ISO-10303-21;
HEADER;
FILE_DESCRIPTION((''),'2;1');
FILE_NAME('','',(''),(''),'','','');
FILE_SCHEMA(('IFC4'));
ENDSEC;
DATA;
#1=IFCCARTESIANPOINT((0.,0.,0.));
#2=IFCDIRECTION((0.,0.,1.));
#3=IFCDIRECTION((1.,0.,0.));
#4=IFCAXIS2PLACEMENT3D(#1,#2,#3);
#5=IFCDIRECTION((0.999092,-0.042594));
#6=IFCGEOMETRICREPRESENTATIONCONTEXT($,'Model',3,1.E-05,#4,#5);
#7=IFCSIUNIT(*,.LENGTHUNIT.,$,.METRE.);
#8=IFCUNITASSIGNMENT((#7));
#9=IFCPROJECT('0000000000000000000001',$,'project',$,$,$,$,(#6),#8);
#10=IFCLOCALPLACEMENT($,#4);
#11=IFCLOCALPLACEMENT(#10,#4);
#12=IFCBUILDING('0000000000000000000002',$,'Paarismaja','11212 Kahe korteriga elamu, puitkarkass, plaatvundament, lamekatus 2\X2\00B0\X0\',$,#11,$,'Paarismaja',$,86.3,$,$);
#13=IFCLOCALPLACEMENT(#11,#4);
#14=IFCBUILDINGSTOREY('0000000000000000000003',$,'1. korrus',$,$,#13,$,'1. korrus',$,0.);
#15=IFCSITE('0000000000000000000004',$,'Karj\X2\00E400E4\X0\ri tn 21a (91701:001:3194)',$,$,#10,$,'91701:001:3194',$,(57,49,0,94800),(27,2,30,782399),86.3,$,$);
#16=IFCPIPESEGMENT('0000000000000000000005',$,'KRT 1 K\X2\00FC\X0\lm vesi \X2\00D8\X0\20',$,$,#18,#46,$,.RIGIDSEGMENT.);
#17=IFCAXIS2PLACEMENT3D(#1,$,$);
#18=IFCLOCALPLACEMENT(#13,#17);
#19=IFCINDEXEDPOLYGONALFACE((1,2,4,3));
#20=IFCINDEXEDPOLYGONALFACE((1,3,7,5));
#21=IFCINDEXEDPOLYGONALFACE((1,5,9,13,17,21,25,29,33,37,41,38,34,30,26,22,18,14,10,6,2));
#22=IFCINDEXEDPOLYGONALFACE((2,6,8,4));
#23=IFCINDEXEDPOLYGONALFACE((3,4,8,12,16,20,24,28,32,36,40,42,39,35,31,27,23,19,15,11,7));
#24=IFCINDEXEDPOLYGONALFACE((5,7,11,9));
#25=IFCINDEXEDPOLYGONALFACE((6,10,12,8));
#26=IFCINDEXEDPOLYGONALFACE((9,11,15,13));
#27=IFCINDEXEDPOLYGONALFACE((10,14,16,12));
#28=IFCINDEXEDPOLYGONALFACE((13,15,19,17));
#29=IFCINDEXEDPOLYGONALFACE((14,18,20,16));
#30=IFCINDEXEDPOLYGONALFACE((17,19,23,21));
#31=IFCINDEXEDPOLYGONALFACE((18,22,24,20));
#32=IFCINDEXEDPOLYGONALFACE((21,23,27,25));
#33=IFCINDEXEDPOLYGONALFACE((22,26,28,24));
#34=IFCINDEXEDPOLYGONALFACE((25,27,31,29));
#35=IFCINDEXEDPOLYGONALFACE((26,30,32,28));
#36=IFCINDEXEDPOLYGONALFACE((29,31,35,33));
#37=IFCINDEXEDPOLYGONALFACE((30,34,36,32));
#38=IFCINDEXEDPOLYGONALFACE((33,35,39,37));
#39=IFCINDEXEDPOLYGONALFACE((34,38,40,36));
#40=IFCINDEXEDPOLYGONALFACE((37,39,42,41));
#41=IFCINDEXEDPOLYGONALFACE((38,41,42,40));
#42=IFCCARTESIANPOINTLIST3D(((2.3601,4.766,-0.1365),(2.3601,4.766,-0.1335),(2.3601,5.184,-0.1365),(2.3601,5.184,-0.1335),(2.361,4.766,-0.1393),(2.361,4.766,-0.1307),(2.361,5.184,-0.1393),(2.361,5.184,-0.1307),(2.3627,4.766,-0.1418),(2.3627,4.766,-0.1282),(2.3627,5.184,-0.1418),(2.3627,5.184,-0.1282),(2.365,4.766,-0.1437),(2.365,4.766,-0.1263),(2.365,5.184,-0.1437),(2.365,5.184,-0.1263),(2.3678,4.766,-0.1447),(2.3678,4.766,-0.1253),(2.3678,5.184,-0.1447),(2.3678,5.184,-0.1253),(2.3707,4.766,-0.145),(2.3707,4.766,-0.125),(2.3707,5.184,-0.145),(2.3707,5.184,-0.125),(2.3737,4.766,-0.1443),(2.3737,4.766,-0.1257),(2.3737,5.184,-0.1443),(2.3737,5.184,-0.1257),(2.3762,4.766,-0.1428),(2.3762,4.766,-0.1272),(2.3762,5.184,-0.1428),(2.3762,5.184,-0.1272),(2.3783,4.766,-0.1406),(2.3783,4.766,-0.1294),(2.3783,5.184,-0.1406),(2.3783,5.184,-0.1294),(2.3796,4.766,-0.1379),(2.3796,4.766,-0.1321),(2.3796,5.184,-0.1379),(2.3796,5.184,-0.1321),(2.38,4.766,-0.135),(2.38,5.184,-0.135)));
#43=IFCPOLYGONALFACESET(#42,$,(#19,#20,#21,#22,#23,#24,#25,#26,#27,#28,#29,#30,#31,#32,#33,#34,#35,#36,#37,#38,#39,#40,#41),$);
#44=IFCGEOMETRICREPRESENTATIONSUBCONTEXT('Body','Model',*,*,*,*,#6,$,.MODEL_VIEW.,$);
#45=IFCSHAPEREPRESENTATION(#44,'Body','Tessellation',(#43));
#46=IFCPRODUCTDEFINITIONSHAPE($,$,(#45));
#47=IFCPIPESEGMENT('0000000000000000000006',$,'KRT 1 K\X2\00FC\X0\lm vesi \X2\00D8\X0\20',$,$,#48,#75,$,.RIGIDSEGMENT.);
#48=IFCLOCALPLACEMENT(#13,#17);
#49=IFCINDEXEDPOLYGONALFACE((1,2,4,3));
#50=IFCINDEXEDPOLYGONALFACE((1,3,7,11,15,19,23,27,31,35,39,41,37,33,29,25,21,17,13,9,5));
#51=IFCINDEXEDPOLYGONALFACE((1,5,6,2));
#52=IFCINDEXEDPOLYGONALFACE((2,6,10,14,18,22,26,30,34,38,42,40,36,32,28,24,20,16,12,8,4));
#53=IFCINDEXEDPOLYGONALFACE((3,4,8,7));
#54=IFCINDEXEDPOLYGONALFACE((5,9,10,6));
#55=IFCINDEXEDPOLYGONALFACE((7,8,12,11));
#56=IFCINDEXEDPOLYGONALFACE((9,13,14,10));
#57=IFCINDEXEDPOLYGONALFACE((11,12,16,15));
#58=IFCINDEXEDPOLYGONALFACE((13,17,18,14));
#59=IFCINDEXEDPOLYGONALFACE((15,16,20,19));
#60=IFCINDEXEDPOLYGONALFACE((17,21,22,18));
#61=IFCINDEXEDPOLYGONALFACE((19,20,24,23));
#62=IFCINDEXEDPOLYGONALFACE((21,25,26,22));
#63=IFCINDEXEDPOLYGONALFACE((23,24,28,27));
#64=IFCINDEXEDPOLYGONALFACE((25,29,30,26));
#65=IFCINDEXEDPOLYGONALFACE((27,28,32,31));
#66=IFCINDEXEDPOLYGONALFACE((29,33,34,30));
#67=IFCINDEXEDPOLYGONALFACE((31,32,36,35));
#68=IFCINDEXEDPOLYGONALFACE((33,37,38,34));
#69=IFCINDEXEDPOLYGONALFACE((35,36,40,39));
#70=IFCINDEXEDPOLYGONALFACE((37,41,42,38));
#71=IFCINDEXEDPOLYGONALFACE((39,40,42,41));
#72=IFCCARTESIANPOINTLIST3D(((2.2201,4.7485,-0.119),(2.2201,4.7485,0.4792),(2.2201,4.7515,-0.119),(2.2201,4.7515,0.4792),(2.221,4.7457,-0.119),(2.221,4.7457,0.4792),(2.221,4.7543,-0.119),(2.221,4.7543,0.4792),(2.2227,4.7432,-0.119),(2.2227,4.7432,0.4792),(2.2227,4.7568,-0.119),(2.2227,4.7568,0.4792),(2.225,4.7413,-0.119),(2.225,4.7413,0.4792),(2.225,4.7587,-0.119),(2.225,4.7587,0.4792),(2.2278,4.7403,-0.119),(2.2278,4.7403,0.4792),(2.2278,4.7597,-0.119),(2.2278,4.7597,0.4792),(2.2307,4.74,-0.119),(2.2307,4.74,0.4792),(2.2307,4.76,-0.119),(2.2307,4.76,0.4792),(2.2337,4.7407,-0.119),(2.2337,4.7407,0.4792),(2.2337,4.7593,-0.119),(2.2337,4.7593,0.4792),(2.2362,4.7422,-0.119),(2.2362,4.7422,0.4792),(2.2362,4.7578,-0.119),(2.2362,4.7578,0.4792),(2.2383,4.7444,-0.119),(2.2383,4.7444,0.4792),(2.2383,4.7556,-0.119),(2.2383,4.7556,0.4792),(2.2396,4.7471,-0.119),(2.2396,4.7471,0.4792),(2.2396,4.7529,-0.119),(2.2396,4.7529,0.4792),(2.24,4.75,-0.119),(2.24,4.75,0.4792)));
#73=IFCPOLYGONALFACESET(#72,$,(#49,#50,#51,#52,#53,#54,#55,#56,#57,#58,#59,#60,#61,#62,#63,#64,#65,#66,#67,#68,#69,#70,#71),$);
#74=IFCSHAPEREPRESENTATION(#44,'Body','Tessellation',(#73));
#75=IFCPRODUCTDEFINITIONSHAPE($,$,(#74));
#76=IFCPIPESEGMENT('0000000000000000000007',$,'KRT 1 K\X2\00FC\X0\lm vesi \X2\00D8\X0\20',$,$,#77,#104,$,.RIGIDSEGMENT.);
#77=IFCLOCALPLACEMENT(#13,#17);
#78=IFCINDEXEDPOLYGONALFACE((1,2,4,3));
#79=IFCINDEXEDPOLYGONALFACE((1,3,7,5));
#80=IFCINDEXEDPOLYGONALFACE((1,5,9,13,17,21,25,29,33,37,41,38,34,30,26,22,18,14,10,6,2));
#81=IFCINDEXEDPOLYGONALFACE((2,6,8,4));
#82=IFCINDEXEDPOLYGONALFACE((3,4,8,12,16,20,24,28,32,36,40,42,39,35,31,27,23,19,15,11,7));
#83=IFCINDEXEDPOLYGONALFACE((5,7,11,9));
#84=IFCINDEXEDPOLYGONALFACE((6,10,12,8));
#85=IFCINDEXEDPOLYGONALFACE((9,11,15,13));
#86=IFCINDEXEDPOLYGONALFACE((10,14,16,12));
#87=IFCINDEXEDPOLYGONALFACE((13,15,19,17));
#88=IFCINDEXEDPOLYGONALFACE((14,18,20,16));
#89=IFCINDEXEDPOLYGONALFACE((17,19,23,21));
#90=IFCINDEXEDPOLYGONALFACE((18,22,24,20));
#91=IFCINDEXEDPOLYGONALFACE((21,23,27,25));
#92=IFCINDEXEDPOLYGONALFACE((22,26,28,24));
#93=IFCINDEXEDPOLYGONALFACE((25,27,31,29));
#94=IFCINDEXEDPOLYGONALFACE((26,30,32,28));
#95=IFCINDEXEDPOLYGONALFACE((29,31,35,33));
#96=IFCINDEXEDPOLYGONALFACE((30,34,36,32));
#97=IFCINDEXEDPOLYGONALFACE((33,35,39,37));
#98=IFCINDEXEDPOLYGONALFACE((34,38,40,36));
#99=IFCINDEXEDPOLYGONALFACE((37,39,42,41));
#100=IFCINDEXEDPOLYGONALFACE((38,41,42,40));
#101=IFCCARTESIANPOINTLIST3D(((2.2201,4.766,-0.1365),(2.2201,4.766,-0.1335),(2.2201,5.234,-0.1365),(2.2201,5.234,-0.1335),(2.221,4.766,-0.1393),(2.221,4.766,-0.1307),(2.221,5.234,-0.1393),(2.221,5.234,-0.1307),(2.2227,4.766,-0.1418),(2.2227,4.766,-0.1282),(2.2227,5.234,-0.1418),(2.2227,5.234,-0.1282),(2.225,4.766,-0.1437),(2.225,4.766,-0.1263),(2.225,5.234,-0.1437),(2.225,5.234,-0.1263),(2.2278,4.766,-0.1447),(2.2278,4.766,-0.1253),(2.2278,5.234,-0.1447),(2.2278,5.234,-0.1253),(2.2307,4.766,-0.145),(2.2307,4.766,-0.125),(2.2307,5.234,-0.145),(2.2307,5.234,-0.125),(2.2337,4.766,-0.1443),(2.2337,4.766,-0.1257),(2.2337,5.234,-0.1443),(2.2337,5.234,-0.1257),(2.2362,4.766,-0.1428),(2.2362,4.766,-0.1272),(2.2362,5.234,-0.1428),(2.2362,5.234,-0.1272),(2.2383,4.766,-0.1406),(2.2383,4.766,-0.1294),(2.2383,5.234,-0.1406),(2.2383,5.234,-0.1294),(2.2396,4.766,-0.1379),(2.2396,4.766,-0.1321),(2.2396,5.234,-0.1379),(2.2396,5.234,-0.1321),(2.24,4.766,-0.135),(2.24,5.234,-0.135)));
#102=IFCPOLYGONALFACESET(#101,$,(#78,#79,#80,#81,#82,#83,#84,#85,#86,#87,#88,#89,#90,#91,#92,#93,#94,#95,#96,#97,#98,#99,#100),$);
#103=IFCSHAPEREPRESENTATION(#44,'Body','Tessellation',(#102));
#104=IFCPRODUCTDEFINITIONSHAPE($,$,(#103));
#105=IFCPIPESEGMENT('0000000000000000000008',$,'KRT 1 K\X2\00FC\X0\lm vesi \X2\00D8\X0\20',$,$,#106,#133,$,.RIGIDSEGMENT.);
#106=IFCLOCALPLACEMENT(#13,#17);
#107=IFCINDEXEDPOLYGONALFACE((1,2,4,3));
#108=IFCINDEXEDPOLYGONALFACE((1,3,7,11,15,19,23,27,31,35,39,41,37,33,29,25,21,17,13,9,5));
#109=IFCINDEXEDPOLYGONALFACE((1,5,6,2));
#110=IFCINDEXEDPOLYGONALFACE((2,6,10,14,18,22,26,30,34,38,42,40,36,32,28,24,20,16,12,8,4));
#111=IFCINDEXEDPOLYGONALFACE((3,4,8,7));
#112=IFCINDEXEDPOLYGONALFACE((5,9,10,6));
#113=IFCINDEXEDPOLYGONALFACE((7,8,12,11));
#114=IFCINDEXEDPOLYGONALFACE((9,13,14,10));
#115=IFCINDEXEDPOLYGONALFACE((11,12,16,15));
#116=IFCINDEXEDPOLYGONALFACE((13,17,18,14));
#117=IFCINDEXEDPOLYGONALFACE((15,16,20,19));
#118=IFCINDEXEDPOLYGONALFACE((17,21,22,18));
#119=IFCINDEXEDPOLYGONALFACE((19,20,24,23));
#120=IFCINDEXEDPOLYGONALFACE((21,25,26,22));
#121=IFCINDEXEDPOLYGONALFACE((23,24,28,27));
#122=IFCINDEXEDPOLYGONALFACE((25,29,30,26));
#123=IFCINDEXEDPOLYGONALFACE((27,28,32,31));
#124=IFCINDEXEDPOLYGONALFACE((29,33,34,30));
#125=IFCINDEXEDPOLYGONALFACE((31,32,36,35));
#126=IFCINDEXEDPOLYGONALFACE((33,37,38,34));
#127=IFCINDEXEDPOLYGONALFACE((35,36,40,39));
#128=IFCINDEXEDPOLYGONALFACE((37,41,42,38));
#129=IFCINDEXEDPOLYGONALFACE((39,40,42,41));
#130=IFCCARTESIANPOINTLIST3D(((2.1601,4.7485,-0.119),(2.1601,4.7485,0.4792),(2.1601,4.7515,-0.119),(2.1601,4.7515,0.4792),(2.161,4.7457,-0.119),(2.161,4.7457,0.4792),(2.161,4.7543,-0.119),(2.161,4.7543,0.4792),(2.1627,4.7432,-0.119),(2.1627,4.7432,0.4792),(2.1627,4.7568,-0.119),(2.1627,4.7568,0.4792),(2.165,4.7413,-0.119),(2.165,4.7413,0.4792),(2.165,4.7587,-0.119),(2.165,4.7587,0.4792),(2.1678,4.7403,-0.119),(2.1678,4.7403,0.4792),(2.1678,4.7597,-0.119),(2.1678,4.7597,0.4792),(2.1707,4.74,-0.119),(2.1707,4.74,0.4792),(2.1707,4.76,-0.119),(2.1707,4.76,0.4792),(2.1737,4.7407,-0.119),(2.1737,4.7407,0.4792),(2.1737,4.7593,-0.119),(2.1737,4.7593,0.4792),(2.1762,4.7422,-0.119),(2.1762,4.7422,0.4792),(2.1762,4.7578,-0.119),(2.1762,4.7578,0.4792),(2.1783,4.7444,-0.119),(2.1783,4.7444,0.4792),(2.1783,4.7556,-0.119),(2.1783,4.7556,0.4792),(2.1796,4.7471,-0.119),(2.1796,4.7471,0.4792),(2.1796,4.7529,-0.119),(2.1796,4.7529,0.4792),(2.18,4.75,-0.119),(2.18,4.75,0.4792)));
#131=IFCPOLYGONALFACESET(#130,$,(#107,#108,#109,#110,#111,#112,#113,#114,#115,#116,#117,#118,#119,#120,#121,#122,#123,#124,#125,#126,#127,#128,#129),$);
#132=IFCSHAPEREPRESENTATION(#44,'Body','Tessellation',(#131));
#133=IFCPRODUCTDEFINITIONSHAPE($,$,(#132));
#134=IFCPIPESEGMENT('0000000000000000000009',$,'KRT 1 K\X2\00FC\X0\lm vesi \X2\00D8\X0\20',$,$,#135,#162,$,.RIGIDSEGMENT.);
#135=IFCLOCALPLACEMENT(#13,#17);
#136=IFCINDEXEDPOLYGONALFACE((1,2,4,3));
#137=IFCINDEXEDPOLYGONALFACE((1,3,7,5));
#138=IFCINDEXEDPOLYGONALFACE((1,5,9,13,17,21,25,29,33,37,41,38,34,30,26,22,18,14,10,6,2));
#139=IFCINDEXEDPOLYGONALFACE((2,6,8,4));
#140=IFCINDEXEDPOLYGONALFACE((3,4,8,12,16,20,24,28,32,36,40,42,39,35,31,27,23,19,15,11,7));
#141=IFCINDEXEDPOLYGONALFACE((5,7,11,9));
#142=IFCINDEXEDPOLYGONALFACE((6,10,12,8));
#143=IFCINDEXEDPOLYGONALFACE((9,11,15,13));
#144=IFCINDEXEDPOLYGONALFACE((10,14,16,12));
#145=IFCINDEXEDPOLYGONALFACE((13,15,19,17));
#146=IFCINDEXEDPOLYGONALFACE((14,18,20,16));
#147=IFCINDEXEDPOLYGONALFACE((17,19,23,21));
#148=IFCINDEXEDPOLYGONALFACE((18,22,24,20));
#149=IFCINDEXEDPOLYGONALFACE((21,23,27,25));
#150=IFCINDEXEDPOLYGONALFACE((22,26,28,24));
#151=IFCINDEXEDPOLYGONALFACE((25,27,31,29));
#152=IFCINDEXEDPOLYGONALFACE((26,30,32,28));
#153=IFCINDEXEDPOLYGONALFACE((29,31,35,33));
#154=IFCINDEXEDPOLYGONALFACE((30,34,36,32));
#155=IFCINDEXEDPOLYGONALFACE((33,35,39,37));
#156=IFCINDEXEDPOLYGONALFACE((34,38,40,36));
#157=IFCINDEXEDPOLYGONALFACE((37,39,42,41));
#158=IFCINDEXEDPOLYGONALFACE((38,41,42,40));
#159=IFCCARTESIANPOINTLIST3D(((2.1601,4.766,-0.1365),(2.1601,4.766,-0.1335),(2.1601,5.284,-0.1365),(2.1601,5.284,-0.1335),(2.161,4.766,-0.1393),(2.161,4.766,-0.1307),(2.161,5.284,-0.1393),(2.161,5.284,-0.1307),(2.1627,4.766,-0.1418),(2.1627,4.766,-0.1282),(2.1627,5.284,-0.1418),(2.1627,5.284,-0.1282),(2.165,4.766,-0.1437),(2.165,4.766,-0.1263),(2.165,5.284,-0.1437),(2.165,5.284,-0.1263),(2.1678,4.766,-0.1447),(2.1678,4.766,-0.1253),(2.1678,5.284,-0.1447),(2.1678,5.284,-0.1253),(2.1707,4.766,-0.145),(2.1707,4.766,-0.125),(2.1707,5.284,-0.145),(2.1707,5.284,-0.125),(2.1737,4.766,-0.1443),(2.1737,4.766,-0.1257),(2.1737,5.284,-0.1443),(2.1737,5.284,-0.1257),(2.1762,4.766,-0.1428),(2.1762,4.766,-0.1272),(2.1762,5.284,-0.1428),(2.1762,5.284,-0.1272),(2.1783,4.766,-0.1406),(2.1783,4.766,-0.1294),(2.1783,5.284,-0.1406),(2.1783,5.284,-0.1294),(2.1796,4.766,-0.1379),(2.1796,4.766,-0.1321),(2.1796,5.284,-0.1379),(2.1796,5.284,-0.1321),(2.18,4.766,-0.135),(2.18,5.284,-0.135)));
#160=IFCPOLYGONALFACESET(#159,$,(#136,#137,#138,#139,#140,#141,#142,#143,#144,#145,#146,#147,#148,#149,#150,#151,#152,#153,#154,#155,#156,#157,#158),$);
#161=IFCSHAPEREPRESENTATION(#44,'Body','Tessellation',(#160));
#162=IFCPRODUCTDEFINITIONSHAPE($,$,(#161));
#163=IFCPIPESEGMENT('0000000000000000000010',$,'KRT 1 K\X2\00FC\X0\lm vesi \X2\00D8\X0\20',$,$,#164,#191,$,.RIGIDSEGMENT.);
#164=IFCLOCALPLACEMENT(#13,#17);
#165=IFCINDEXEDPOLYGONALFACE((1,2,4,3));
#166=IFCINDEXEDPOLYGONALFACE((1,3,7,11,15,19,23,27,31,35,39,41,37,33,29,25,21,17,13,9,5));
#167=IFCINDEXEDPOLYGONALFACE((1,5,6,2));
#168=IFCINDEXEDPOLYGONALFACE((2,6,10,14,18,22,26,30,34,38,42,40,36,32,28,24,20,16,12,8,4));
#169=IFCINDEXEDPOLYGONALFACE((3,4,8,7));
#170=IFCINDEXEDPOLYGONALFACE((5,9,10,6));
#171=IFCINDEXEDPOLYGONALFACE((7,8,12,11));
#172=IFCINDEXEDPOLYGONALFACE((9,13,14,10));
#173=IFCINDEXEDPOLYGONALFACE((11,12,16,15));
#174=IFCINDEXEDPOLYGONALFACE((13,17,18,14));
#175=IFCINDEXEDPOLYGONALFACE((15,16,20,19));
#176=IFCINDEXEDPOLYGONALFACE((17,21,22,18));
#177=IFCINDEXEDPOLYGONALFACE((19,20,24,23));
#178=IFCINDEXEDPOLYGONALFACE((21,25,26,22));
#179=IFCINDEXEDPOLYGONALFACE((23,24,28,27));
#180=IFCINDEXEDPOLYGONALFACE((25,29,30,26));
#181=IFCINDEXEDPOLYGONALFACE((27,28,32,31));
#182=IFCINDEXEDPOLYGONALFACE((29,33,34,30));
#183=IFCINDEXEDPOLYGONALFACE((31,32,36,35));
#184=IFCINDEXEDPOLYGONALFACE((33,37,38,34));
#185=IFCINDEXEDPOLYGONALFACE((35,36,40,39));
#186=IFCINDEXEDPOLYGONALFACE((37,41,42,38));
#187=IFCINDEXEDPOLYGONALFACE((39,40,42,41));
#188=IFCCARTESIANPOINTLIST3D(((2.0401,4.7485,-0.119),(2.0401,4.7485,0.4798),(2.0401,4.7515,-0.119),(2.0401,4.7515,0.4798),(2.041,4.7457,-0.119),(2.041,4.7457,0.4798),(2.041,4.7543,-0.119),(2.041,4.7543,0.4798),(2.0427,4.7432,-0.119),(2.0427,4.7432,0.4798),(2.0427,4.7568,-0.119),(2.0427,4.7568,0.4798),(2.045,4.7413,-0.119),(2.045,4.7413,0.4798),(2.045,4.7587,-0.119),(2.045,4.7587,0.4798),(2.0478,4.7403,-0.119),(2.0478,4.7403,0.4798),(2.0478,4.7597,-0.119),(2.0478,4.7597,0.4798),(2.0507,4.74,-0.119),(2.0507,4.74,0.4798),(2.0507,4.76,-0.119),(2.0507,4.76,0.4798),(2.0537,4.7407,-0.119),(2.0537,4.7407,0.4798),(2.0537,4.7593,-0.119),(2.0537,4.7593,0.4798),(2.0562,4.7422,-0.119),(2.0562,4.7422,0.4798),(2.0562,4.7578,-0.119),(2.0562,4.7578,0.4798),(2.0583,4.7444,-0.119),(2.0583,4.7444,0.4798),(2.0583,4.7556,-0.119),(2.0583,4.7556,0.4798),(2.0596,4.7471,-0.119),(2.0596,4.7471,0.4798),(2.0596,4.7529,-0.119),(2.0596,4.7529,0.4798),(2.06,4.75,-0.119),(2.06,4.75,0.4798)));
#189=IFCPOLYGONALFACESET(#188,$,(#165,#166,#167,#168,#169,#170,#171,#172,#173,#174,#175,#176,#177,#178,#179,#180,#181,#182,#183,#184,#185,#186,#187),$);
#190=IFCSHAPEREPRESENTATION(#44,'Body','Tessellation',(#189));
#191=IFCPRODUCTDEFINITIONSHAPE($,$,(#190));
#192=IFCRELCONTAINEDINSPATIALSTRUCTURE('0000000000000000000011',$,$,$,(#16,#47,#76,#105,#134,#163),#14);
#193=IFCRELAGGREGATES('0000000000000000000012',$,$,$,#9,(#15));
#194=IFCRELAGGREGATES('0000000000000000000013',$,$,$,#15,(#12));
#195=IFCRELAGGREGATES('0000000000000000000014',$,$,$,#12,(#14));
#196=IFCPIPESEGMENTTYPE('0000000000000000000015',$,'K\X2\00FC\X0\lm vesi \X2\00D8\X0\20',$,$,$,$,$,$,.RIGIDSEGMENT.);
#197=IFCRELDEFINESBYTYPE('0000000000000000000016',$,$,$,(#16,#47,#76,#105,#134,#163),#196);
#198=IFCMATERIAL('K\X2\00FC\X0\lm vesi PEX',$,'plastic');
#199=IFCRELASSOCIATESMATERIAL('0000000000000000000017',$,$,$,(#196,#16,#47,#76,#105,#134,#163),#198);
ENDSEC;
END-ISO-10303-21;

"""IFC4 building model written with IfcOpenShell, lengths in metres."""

from ifc_helpers import new_model, si_unit, direction, frame, origin_with_axes, place, context, subcontext, project, spatial, circle, extrude, material, type_object, element, save


model = new_model("IFC4")

# Units and contexts
model_context = context("Model", 3, precision=1e-05, world=origin_with_axes(), true_north=direction((0.999092, -0.042594)))
body_context = subcontext(model_context, "Body", "Model", "MODEL_VIEW")
ifc_project = project(units=[si_unit("LENGTHUNIT", "METRE")], contexts=[model_context])

# Site, building, storey
site_placement = place(None, origin_with_axes())
site = spatial("IfcSite", under=ifc_project, at=site_placement, Name="Karjääri tn 21a (91701:001:3194)", LongName="91701:001:3194", RefLatitude=(57, 49, 0, 94800), RefLongitude=(27, 2, 30, 782399), RefElevation=86.3)
building_placement = place(site_placement, origin_with_axes())
building = spatial("IfcBuilding", under=site, at=building_placement, Name="Paarismaja", Description="11212 Kahe korteriga elamu, puitkarkass, plaatvundament, lamekatus 2°", LongName="Paarismaja", ElevationOfRefHeight=86.3)
storey_placement = place(building_placement, origin_with_axes())
storey = spatial("IfcBuildingStorey", under=building, at=storey_placement, Name="1. korrus", LongName="1. korrus", Elevation=0.0)

# Shared definitions
ifc_material_1 = material(Name="Külm vesi PEX", Category="plastic")

# Pipe segments
pipe_segment_type_1 = type_object("IfcPipeSegmentType", Name="Külm vesi Ø20", PredefinedType="RIGIDSEGMENT", material=ifc_material_1)
pipe_segment_1_placement = place(storey_placement, frame((2.37, 4.766, -0.135), z_axis=(0.0, 1.0, 0.0), x_axis=(1.0, 0.0, 0.0)))
element("IfcPipeSegment", 1, at=pipe_segment_1_placement, inside=storey, type_object=pipe_segment_type_1, material=ifc_material_1, Name="KRT 1 Külm vesi Ø20", PredefinedType="RIGIDSEGMENT", context=body_context, shape_type="SweptSolid", body=[
    extrude(circle(Radius=0.01), origin_with_axes(), (0.0, 0.0, 1.0), 0.418),
])
pipe_segment_2_placement = place(storey_placement, frame((2.23, 4.75, 0.4792), z_axis=(0.0, 0.0, -1.0), x_axis=(1.0, 0.0, 0.0)))
element("IfcPipeSegment", 2, at=pipe_segment_2_placement, inside=storey, type_object=pipe_segment_type_1, material=ifc_material_1, Name="KRT 1 Külm vesi Ø20", PredefinedType="RIGIDSEGMENT", context=body_context, shape_type="SweptSolid", body=[
    extrude(circle(Radius=0.01), origin_with_axes(), (0.0, 0.0, 1.0), 0.5982),
])
pipe_segment_3_placement = place(storey_placement, frame((2.23, 4.766, -0.135), z_axis=(0.0, 1.0, 0.0), x_axis=(1.0, 0.0, 0.0)))
element("IfcPipeSegment", 3, at=pipe_segment_3_placement, inside=storey, type_object=pipe_segment_type_1, material=ifc_material_1, Name="KRT 1 Külm vesi Ø20", PredefinedType="RIGIDSEGMENT", context=body_context, shape_type="SweptSolid", body=[
    extrude(circle(Radius=0.01), origin_with_axes(), (0.0, 0.0, 1.0), 0.468),
])
pipe_segment_4_placement = place(storey_placement, frame((2.17, 4.75, 0.4792), z_axis=(0.0, 0.0, -1.0), x_axis=(1.0, 0.0, 0.0)))
element("IfcPipeSegment", 4, at=pipe_segment_4_placement, inside=storey, type_object=pipe_segment_type_1, material=ifc_material_1, Name="KRT 1 Külm vesi Ø20", PredefinedType="RIGIDSEGMENT", context=body_context, shape_type="SweptSolid", body=[
    extrude(circle(Radius=0.01), origin_with_axes(), (0.0, 0.0, 1.0), 0.5982),
])
pipe_segment_5_placement = place(storey_placement, frame((2.17, 4.766, -0.135), z_axis=(0.0, 1.0, 0.0), x_axis=(1.0, 0.0, 0.0)))
element("IfcPipeSegment", 5, at=pipe_segment_5_placement, inside=storey, type_object=pipe_segment_type_1, material=ifc_material_1, Name="KRT 1 Külm vesi Ø20", PredefinedType="RIGIDSEGMENT", context=body_context, shape_type="SweptSolid", body=[
    extrude(circle(Radius=0.01), origin_with_axes(), (0.0, 0.0, 1.0), 0.518),
])
pipe_segment_6_placement = place(storey_placement, frame((2.05, 4.75, 0.4798), z_axis=(0.0, 0.0, -1.0), x_axis=(1.0, 0.0, 0.0)))
element("IfcPipeSegment", 6, at=pipe_segment_6_placement, inside=storey, type_object=pipe_segment_type_1, material=ifc_material_1, Name="KRT 1 Külm vesi Ø20", PredefinedType="RIGIDSEGMENT", context=body_context, shape_type="SweptSolid", body=[
    extrude(circle(Radius=0.01), origin_with_axes(), (0.0, 0.0, 1.0), 0.5988),
])

save(model, "model.ifc")
